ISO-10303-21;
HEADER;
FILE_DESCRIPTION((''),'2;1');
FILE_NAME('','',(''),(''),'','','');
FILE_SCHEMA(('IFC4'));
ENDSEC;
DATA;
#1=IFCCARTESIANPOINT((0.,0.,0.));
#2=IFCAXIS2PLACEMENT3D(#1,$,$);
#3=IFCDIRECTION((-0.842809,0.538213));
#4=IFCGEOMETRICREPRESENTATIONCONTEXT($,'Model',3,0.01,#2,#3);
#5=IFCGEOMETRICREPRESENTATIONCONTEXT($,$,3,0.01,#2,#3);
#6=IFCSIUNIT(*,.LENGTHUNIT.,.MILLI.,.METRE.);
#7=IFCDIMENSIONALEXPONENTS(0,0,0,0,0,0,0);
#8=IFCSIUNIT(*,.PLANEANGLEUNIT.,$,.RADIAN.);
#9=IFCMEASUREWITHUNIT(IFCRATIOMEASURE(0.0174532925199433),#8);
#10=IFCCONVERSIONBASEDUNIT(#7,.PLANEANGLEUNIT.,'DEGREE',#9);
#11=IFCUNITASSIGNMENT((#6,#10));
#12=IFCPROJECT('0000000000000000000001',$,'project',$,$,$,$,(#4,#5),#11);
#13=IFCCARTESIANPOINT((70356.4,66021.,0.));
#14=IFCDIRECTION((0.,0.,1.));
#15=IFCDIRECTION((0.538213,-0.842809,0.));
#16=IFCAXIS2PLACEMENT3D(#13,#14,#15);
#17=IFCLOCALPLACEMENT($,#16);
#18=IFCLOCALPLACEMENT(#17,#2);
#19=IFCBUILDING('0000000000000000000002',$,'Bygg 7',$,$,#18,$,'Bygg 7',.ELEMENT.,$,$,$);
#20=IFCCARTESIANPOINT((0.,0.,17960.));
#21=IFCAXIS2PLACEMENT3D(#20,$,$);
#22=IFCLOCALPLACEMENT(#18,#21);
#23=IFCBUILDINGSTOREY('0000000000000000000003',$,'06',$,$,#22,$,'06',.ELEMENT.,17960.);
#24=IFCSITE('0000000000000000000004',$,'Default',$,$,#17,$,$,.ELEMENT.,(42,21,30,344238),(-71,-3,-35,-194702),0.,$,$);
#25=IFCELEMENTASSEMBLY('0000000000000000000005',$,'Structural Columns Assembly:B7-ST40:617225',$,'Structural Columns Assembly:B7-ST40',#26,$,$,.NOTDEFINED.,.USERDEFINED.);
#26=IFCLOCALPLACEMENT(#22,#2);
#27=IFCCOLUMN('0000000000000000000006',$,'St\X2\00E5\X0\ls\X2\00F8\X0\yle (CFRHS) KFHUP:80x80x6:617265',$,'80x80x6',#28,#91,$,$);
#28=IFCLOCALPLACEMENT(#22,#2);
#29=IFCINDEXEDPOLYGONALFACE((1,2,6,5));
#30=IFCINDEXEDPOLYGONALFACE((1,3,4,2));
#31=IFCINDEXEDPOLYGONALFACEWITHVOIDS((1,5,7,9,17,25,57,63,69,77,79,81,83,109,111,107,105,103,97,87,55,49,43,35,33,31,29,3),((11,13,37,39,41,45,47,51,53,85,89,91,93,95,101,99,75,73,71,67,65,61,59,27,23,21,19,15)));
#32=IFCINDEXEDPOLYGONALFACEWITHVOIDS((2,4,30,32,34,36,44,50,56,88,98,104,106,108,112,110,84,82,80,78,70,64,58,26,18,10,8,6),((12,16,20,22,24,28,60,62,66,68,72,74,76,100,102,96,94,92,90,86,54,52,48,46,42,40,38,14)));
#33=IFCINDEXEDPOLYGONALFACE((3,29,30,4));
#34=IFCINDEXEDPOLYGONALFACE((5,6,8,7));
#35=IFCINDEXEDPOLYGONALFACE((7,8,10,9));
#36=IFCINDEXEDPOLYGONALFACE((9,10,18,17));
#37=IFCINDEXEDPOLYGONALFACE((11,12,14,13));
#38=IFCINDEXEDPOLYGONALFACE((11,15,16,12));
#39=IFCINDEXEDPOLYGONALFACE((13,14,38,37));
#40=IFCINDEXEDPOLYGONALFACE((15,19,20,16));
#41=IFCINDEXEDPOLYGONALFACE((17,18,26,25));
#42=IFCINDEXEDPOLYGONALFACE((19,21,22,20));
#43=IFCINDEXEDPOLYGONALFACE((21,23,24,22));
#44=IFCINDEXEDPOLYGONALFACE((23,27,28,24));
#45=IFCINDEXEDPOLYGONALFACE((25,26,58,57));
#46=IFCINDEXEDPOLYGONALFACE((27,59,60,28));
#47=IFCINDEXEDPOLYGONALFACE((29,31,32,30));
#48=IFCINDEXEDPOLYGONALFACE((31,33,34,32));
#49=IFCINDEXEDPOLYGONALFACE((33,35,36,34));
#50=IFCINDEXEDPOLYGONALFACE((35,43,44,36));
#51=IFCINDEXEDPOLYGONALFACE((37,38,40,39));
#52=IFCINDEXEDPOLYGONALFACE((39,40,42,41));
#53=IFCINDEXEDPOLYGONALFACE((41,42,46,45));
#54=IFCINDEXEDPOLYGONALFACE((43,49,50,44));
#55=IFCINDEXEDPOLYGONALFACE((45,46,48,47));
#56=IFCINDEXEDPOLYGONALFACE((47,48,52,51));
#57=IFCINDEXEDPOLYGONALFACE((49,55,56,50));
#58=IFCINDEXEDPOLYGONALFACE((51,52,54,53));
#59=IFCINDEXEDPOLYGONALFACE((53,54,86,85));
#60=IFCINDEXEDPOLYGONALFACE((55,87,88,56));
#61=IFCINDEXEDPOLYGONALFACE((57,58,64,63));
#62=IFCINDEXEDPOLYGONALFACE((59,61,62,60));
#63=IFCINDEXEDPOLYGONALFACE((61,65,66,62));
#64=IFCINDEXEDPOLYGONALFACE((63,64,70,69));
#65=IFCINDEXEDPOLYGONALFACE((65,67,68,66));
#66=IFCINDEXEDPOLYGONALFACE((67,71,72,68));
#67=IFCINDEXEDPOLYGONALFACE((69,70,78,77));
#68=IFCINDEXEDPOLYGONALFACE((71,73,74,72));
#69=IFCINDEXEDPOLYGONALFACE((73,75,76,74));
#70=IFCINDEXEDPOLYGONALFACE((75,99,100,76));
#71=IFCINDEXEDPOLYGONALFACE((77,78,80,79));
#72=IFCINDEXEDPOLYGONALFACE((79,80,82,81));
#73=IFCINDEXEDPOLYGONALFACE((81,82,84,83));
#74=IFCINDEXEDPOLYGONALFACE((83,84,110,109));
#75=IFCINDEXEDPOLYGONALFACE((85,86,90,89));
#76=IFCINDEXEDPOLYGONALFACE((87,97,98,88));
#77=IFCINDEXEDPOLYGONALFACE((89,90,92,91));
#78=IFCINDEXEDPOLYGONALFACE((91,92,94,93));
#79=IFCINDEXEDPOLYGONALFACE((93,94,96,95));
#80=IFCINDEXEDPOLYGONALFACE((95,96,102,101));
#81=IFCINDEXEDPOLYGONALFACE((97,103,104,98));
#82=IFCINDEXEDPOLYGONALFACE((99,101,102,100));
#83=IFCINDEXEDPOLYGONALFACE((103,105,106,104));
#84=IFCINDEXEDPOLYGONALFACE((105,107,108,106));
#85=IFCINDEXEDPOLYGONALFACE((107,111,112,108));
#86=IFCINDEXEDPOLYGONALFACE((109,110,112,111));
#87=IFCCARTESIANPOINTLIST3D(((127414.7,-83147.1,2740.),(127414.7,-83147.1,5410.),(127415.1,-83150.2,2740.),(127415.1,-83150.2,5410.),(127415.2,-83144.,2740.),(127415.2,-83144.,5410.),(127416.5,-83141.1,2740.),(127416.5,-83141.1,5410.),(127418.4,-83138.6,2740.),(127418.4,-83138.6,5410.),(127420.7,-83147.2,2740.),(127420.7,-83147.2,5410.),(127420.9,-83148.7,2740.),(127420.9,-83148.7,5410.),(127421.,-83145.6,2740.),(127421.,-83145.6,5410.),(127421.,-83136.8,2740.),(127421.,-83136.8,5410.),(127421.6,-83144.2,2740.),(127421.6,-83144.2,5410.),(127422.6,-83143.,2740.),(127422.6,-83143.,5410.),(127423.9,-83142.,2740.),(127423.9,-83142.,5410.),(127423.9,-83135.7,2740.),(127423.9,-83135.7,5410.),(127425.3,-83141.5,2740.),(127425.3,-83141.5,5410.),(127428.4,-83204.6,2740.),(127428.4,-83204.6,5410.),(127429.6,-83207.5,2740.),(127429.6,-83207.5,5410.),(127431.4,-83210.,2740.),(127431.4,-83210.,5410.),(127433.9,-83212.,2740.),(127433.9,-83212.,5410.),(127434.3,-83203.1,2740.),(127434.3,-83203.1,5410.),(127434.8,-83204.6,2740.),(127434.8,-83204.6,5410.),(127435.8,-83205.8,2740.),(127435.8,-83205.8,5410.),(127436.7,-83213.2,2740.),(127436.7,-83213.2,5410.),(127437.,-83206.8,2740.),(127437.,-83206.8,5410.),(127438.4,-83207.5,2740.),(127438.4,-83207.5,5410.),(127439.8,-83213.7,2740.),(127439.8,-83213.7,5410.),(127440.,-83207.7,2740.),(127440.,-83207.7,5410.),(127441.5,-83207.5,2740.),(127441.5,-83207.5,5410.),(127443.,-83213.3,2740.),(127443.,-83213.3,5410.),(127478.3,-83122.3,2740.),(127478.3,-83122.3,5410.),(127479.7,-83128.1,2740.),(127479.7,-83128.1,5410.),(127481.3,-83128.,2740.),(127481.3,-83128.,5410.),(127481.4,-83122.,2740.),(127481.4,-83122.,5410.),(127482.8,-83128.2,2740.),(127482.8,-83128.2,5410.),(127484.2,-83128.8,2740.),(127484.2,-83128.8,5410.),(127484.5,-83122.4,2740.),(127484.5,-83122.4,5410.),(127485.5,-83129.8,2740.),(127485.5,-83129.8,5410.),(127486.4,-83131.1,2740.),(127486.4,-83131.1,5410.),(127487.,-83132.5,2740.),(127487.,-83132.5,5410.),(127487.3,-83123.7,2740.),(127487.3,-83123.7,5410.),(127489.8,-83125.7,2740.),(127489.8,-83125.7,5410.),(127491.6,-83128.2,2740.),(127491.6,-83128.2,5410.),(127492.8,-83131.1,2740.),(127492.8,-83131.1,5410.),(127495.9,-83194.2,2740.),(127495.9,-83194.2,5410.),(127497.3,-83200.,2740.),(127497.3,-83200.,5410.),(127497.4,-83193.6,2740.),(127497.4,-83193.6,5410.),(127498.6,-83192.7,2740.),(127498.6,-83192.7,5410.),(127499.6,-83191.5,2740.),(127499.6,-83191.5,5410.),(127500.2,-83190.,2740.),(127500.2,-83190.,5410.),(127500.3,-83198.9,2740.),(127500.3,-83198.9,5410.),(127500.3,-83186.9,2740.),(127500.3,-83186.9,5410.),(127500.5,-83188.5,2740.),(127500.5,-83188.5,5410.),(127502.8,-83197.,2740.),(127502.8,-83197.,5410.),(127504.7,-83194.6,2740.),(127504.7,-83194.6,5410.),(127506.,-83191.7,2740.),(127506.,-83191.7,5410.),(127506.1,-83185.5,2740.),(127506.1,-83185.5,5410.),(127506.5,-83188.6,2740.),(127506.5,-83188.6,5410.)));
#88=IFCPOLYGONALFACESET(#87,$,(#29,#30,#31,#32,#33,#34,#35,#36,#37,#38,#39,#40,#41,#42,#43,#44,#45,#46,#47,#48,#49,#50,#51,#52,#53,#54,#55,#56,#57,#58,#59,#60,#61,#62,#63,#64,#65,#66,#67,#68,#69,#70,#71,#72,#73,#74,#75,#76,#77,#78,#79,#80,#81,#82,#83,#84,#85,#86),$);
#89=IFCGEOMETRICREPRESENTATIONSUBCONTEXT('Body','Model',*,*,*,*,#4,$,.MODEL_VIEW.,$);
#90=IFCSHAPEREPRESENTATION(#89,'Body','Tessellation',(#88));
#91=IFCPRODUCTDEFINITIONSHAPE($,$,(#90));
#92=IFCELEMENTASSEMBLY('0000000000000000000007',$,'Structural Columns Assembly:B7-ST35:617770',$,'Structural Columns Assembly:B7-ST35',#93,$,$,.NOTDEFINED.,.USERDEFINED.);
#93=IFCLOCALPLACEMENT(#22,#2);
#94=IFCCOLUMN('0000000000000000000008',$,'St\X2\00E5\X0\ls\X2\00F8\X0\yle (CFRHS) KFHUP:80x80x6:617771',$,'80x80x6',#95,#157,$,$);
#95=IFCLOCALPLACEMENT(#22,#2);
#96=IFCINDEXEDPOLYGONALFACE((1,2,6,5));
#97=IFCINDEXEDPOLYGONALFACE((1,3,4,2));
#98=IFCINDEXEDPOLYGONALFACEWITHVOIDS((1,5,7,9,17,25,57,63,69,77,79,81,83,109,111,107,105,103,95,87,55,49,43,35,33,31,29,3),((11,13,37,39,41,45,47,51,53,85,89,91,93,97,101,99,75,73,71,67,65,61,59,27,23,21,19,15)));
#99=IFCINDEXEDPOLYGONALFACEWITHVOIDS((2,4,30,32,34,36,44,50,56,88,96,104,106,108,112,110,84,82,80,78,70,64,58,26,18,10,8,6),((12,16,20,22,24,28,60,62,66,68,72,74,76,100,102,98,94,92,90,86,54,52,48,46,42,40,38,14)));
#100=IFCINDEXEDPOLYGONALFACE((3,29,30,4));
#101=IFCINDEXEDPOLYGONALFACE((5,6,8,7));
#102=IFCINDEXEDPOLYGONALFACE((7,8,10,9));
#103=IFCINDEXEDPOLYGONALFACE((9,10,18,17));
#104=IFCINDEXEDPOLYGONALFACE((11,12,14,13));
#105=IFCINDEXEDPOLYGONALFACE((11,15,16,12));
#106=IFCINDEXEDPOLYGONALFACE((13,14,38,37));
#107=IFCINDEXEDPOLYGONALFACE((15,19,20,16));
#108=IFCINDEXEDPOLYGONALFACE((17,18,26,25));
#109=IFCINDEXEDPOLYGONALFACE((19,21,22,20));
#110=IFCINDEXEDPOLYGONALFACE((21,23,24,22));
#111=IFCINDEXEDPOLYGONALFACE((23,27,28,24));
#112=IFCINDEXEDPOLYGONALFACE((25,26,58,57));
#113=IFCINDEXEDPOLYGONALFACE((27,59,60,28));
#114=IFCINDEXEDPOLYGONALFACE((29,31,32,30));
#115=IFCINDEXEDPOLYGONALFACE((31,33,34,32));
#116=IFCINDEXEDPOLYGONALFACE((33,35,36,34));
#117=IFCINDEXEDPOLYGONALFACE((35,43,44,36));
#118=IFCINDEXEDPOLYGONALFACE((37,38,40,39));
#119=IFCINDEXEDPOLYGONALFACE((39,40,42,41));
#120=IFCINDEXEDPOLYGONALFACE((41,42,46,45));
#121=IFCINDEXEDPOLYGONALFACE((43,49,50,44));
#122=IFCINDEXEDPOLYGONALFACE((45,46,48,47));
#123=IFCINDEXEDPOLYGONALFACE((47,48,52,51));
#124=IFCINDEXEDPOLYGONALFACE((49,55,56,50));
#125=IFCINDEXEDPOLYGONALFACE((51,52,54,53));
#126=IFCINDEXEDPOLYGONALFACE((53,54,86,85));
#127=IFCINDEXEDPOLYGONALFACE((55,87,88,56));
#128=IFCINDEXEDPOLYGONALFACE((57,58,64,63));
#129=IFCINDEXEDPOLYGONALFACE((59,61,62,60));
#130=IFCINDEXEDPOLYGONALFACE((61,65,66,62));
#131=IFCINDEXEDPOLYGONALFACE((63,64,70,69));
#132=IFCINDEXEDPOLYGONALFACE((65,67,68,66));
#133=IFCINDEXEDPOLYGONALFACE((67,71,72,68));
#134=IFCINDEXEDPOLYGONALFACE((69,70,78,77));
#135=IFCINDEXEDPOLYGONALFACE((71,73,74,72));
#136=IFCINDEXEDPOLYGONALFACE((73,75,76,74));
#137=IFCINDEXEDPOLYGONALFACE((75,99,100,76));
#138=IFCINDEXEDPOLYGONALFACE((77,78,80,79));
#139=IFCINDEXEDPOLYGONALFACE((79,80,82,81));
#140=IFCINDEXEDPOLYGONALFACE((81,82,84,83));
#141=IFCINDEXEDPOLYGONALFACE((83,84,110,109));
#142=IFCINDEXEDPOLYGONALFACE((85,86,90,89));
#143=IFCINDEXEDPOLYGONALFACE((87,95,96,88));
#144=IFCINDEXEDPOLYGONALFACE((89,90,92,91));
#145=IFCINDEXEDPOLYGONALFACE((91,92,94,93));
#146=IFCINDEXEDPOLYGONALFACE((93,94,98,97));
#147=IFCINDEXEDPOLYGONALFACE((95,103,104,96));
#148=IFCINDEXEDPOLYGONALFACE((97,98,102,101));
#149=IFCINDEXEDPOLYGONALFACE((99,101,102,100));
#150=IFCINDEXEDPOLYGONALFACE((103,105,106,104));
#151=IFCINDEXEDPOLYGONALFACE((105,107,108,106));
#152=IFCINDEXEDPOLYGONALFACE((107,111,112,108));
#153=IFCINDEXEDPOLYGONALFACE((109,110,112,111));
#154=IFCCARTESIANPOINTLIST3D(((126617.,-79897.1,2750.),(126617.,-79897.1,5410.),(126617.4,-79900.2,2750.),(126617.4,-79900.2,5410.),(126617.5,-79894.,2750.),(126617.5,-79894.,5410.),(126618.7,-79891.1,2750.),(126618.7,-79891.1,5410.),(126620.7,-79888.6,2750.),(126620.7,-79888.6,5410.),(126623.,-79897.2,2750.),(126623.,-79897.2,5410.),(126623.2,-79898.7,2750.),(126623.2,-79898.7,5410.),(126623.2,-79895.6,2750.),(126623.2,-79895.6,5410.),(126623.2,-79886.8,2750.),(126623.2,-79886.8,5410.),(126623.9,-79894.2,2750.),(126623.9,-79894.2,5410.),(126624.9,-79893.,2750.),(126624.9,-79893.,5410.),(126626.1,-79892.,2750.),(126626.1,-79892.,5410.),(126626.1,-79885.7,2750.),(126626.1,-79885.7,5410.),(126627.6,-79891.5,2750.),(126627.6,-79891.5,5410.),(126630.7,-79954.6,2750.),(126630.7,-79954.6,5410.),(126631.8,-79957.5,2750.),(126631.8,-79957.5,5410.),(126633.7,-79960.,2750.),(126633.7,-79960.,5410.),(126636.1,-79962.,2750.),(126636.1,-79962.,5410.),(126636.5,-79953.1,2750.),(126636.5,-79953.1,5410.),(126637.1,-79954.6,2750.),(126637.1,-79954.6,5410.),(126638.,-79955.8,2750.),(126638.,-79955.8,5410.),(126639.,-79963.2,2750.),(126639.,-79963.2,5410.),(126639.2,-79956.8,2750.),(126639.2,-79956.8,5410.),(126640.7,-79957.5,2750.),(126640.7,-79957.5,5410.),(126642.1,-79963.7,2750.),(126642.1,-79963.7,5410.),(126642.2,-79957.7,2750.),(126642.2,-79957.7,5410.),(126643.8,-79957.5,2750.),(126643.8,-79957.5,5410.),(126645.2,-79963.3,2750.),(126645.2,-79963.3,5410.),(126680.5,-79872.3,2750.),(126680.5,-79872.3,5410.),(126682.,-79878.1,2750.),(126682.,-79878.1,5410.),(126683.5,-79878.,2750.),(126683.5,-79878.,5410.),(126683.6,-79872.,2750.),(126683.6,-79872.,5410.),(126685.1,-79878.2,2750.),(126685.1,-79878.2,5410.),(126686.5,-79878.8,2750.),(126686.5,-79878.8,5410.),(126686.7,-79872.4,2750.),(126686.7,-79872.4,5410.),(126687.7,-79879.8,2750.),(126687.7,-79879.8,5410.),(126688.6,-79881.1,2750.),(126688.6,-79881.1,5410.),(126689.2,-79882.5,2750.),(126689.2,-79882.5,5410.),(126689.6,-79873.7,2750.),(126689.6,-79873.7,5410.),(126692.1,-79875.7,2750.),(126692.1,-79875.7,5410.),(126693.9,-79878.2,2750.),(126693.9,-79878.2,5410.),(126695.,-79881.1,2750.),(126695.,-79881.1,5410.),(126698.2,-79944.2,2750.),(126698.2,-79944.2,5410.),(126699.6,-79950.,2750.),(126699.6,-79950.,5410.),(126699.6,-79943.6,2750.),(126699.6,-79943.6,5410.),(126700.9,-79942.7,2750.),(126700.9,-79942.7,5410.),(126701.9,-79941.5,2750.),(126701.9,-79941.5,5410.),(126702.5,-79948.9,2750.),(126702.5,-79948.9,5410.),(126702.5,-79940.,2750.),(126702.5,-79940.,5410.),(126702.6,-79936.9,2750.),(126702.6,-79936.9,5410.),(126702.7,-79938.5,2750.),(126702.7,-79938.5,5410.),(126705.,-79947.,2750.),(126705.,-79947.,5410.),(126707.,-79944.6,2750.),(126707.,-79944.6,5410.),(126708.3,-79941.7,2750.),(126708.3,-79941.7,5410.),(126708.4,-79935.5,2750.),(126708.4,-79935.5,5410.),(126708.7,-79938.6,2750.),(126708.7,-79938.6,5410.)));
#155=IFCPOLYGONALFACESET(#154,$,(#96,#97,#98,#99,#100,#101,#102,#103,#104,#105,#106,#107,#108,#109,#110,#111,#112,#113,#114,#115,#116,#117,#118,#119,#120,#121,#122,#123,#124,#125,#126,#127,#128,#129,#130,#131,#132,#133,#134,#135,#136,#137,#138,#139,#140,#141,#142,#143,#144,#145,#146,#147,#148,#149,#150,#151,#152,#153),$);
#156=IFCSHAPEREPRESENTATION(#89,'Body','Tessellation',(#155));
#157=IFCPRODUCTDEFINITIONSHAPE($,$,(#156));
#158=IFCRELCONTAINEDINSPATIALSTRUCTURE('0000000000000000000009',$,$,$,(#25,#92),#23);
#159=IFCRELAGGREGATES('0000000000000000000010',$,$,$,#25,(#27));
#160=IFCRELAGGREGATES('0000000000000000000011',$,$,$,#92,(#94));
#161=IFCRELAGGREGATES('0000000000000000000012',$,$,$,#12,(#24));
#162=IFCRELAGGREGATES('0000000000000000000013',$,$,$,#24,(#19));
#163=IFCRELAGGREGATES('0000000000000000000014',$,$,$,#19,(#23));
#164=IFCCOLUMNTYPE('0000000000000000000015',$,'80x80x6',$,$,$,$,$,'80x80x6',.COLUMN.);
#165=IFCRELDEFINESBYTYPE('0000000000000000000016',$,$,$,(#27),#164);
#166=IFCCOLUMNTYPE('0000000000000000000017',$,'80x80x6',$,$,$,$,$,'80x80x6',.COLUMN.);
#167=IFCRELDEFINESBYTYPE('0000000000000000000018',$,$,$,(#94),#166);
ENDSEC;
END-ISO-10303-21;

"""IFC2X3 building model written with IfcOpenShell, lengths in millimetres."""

from ifc_helpers import new_model, entity, si_unit, converted_unit, direction, frame, frame_2d, origin, place, context, subcontext, project, spatial, polyline, circle_curve, parameter, trimmed, segment, composite_curve, outline, extrude, source, transform, mapped, type_object, type_shapes, element, aggregate, save


model = new_model("IFC2X3")

# Units and contexts
model_context = context("Model", 3, precision=0.01, world=origin(), true_north=direction((-0.842809, 0.538213)))
context_of_model = context(None, 3, precision=0.01, world=origin(), true_north=direction((-0.842809, 0.538213)))
body_context = subcontext(model_context, "Body", "Model", "MODEL_VIEW")
ifc_project = project(units=[si_unit("LENGTHUNIT", "METRE", prefix="MILLI"), converted_unit("PLANEANGLEUNIT", "DEGREE", entity("IfcRatioMeasure", 0.0174532925199433), si_unit("PLANEANGLEUNIT", "RADIAN"), dimensions=[0, 0, 0, 0, 0, 0, 0])], contexts=[model_context, context_of_model])

# Site, building, storey
site_placement = place(None, frame((70356.4, 66021.0, 0.0), z_axis=(0.0, 0.0, 1.0), x_axis=(0.538213, -0.842809, 0.0)))
site = spatial("IfcSite", under=ifc_project, at=site_placement, Name="Default", CompositionType="ELEMENT", RefLatitude=(42, 21, 30, 344238), RefLongitude=(-71, -3, -35, -194702), RefElevation=0.0)
building_placement = place(site_placement, origin())
building = spatial("IfcBuilding", under=site, at=building_placement, Name="Bygg 7", LongName="Bygg 7", CompositionType="ELEMENT")
storey_placement = place(building_placement, frame((0.0, 0.0, 17960.0)))
storey = spatial("IfcBuildingStorey", under=building, at=storey_placement, Name="06", LongName="06", CompositionType="ELEMENT", Elevation=17960.0)

# Element assemblies, columns
assembly_1_placement = place(storey_placement, origin())
assembly_1 = element("IfcElementAssembly", 1, at=assembly_1_placement, inside=storey, Name="Structural Columns Assembly:B7-ST40:617225", ObjectType="Structural Columns Assembly:B7-ST40", AssemblyPlace="NOTDEFINED", PredefinedType="USERDEFINED")
column_type_1 = type_object("IfcColumnType", Name="80x80x6", ElementType="80x80x6", PredefinedType="COLUMN")
shared_shape_1 = source(origin(), body_context, "Body", "SweptSolid", [
    extrude(outline(composite_curve([segment(trimmed(circle_curve(frame_2d((-28.0, 28.0), x_axis=(1.0, 0.0)), 12.0), [parameter(90.0)], [parameter(180.0)], True, "PARAMETER"), True, "CONTINUOUS"), segment(polyline([(-40.0, 28.0), (-40.0, -28.0)]), True, "CONTINUOUS"), segment(trimmed(circle_curve(frame_2d((-28.0, -28.0), x_axis=(1.0, 0.0)), 12.0), [parameter(180.0)], [parameter(270.0)], True, "PARAMETER"), True, "CONTINUOUS"), segment(polyline([(-28.0, -40.0), (28.0, -40.0)]), True, "CONTINUOUS"), segment(trimmed(circle_curve(frame_2d((28.0, -28.0), x_axis=(1.0, 0.0)), 12.0), [parameter(270.0)], [parameter(0.0)], True, "PARAMETER"), True, "CONTINUOUS"), segment(polyline([(40.0, -28.0), (40.0, 28.0)]), True, "CONTINUOUS"), segment(trimmed(circle_curve(frame_2d((28.0, 28.0), x_axis=(1.0, 0.0)), 12.0), [parameter(0.0)], [parameter(90.0)], True, "PARAMETER"), True, "CONTINUOUS"), segment(polyline([(28.0, 40.0), (-28.0, 40.0)]), True, "CONTINUOUS")], self_intersect=False), holes=[composite_curve([segment(polyline([(-28.0, 34.0), (28.0, 34.0)]), True, "CONTINUOUS"), segment(trimmed(circle_curve(frame_2d((28.0, 28.0), x_axis=(1.0, 0.0)), 6.0), [parameter(360.0)], [parameter(90.0)], True, "PARAMETER"), False, "CONTINUOUS"), segment(polyline([(34.0, 28.0), (34.0, -28.0)]), True, "CONTINUOUS"), segment(trimmed(circle_curve(frame_2d((28.0, -28.0), x_axis=(1.0, 0.0)), 6.0), [parameter(270.0)], [parameter(360.0)], True, "PARAMETER"), False, "CONTINUOUS"), segment(polyline([(28.0, -34.0), (-28.0, -34.0)]), True, "CONTINUOUS"), segment(trimmed(circle_curve(frame_2d((-28.0, -28.0), x_axis=(1.0, 0.0)), 6.0), [parameter(180.0)], [parameter(270.0)], True, "PARAMETER"), False, "CONTINUOUS"), segment(polyline([(-34.0, -28.0), (-34.0, 28.0)]), True, "CONTINUOUS"), segment(trimmed(circle_curve(frame_2d((-28.0, 28.0), x_axis=(1.0, 0.0)), 6.0), [parameter(90.0)], [parameter(180.0)], True, "PARAMETER"), False, "CONTINUOUS")], self_intersect=False)]), frame((47.5, 47.5, 0.0), z_axis=(0.0, 0.0, 1.0), x_axis=(-0.971172, -0.238381, 0.0)), (0.0, 0.0, 1.0), 2670.0),
])
type_shapes(column_type_1, [shared_shape_1])
column_1_placement = place(assembly_1_placement, frame((127413.1, -83215.3, 2740.0)))
column_1 = element("IfcColumn", 2, at=column_1_placement, type_object=column_type_1, Name="Stålsøyle (CFRHS) KFHUP:80x80x6:617265", ObjectType="80x80x6", context=body_context, shape_type="MappedRepresentation", body=[
    mapped(shared_shape_1, transform((0.0, 0.0, 0.0), scale=1.0)),
])
assembly_2_placement = place(storey_placement, origin())
assembly_2 = element("IfcElementAssembly", 3, at=assembly_2_placement, inside=storey, Name="Structural Columns Assembly:B7-ST35:617770", ObjectType="Structural Columns Assembly:B7-ST35", AssemblyPlace="NOTDEFINED", PredefinedType="USERDEFINED")
column_type_2 = type_object("IfcColumnType", Name="80x80x6", ElementType="80x80x6", PredefinedType="COLUMN")
shared_shape_2 = source(origin(), body_context, "Body", "SweptSolid", [
    extrude(outline(composite_curve([segment(trimmed(circle_curve(frame_2d((-28.0, 28.0), x_axis=(1.0, 0.0)), 12.0), [parameter(90.0)], [parameter(180.0)], True, "PARAMETER"), True, "CONTINUOUS"), segment(polyline([(-40.0, 28.0), (-40.0, -28.0)]), True, "CONTINUOUS"), segment(trimmed(circle_curve(frame_2d((-28.0, -28.0), x_axis=(1.0, 0.0)), 12.0), [parameter(180.0)], [parameter(270.0)], True, "PARAMETER"), True, "CONTINUOUS"), segment(polyline([(-28.0, -40.0), (28.0, -40.0)]), True, "CONTINUOUS"), segment(trimmed(circle_curve(frame_2d((28.0, -28.0), x_axis=(1.0, 0.0)), 12.0), [parameter(270.0)], [parameter(0.0)], True, "PARAMETER"), True, "CONTINUOUS"), segment(polyline([(40.0, -28.0), (40.0, 28.0)]), True, "CONTINUOUS"), segment(trimmed(circle_curve(frame_2d((28.0, 28.0), x_axis=(1.0, 0.0)), 12.0), [parameter(0.0)], [parameter(90.0)], True, "PARAMETER"), True, "CONTINUOUS"), segment(polyline([(28.0, 40.0), (-28.0, 40.0)]), True, "CONTINUOUS")], self_intersect=False), holes=[composite_curve([segment(polyline([(-28.0, 34.0), (28.0, 34.0)]), True, "CONTINUOUS"), segment(trimmed(circle_curve(frame_2d((28.0, 28.0), x_axis=(1.0, 0.0)), 6.0), [parameter(360.0)], [parameter(90.0)], True, "PARAMETER"), False, "CONTINUOUS"), segment(polyline([(34.0, 28.0), (34.0, -28.0)]), True, "CONTINUOUS"), segment(trimmed(circle_curve(frame_2d((28.0, -28.0), x_axis=(1.0, 0.0)), 6.0), [parameter(270.0)], [parameter(360.0)], True, "PARAMETER"), False, "CONTINUOUS"), segment(polyline([(28.0, -34.0), (-28.0, -34.0)]), True, "CONTINUOUS"), segment(trimmed(circle_curve(frame_2d((-28.0, -28.0), x_axis=(1.0, 0.0)), 6.0), [parameter(180.0)], [parameter(270.0)], True, "PARAMETER"), False, "CONTINUOUS"), segment(polyline([(-34.0, -28.0), (-34.0, 28.0)]), True, "CONTINUOUS"), segment(trimmed(circle_curve(frame_2d((-28.0, 28.0), x_axis=(1.0, 0.0)), 6.0), [parameter(90.0)], [parameter(180.0)], True, "PARAMETER"), False, "CONTINUOUS")], self_intersect=False)]), frame((47.5, 47.5, 0.0), z_axis=(0.0, 0.0, 1.0), x_axis=(-0.971172, -0.238381, 0.0)), (0.0, 0.0, 1.0), 2660.0),
])
type_shapes(column_type_2, [shared_shape_2])
column_2_placement = place(assembly_2_placement, frame((126615.4, -79965.3, 2750.0)))
column_2 = element("IfcColumn", 4, at=column_2_placement, type_object=column_type_2, Name="Stålsøyle (CFRHS) KFHUP:80x80x6:617771", ObjectType="80x80x6", context=body_context, shape_type="MappedRepresentation", body=[
    mapped(shared_shape_2, transform((0.0, 0.0, 0.0), scale=1.0)),
])

aggregate(assembly_1, [column_1])
aggregate(assembly_2, [column_2])

save(model, "model.ifc")
